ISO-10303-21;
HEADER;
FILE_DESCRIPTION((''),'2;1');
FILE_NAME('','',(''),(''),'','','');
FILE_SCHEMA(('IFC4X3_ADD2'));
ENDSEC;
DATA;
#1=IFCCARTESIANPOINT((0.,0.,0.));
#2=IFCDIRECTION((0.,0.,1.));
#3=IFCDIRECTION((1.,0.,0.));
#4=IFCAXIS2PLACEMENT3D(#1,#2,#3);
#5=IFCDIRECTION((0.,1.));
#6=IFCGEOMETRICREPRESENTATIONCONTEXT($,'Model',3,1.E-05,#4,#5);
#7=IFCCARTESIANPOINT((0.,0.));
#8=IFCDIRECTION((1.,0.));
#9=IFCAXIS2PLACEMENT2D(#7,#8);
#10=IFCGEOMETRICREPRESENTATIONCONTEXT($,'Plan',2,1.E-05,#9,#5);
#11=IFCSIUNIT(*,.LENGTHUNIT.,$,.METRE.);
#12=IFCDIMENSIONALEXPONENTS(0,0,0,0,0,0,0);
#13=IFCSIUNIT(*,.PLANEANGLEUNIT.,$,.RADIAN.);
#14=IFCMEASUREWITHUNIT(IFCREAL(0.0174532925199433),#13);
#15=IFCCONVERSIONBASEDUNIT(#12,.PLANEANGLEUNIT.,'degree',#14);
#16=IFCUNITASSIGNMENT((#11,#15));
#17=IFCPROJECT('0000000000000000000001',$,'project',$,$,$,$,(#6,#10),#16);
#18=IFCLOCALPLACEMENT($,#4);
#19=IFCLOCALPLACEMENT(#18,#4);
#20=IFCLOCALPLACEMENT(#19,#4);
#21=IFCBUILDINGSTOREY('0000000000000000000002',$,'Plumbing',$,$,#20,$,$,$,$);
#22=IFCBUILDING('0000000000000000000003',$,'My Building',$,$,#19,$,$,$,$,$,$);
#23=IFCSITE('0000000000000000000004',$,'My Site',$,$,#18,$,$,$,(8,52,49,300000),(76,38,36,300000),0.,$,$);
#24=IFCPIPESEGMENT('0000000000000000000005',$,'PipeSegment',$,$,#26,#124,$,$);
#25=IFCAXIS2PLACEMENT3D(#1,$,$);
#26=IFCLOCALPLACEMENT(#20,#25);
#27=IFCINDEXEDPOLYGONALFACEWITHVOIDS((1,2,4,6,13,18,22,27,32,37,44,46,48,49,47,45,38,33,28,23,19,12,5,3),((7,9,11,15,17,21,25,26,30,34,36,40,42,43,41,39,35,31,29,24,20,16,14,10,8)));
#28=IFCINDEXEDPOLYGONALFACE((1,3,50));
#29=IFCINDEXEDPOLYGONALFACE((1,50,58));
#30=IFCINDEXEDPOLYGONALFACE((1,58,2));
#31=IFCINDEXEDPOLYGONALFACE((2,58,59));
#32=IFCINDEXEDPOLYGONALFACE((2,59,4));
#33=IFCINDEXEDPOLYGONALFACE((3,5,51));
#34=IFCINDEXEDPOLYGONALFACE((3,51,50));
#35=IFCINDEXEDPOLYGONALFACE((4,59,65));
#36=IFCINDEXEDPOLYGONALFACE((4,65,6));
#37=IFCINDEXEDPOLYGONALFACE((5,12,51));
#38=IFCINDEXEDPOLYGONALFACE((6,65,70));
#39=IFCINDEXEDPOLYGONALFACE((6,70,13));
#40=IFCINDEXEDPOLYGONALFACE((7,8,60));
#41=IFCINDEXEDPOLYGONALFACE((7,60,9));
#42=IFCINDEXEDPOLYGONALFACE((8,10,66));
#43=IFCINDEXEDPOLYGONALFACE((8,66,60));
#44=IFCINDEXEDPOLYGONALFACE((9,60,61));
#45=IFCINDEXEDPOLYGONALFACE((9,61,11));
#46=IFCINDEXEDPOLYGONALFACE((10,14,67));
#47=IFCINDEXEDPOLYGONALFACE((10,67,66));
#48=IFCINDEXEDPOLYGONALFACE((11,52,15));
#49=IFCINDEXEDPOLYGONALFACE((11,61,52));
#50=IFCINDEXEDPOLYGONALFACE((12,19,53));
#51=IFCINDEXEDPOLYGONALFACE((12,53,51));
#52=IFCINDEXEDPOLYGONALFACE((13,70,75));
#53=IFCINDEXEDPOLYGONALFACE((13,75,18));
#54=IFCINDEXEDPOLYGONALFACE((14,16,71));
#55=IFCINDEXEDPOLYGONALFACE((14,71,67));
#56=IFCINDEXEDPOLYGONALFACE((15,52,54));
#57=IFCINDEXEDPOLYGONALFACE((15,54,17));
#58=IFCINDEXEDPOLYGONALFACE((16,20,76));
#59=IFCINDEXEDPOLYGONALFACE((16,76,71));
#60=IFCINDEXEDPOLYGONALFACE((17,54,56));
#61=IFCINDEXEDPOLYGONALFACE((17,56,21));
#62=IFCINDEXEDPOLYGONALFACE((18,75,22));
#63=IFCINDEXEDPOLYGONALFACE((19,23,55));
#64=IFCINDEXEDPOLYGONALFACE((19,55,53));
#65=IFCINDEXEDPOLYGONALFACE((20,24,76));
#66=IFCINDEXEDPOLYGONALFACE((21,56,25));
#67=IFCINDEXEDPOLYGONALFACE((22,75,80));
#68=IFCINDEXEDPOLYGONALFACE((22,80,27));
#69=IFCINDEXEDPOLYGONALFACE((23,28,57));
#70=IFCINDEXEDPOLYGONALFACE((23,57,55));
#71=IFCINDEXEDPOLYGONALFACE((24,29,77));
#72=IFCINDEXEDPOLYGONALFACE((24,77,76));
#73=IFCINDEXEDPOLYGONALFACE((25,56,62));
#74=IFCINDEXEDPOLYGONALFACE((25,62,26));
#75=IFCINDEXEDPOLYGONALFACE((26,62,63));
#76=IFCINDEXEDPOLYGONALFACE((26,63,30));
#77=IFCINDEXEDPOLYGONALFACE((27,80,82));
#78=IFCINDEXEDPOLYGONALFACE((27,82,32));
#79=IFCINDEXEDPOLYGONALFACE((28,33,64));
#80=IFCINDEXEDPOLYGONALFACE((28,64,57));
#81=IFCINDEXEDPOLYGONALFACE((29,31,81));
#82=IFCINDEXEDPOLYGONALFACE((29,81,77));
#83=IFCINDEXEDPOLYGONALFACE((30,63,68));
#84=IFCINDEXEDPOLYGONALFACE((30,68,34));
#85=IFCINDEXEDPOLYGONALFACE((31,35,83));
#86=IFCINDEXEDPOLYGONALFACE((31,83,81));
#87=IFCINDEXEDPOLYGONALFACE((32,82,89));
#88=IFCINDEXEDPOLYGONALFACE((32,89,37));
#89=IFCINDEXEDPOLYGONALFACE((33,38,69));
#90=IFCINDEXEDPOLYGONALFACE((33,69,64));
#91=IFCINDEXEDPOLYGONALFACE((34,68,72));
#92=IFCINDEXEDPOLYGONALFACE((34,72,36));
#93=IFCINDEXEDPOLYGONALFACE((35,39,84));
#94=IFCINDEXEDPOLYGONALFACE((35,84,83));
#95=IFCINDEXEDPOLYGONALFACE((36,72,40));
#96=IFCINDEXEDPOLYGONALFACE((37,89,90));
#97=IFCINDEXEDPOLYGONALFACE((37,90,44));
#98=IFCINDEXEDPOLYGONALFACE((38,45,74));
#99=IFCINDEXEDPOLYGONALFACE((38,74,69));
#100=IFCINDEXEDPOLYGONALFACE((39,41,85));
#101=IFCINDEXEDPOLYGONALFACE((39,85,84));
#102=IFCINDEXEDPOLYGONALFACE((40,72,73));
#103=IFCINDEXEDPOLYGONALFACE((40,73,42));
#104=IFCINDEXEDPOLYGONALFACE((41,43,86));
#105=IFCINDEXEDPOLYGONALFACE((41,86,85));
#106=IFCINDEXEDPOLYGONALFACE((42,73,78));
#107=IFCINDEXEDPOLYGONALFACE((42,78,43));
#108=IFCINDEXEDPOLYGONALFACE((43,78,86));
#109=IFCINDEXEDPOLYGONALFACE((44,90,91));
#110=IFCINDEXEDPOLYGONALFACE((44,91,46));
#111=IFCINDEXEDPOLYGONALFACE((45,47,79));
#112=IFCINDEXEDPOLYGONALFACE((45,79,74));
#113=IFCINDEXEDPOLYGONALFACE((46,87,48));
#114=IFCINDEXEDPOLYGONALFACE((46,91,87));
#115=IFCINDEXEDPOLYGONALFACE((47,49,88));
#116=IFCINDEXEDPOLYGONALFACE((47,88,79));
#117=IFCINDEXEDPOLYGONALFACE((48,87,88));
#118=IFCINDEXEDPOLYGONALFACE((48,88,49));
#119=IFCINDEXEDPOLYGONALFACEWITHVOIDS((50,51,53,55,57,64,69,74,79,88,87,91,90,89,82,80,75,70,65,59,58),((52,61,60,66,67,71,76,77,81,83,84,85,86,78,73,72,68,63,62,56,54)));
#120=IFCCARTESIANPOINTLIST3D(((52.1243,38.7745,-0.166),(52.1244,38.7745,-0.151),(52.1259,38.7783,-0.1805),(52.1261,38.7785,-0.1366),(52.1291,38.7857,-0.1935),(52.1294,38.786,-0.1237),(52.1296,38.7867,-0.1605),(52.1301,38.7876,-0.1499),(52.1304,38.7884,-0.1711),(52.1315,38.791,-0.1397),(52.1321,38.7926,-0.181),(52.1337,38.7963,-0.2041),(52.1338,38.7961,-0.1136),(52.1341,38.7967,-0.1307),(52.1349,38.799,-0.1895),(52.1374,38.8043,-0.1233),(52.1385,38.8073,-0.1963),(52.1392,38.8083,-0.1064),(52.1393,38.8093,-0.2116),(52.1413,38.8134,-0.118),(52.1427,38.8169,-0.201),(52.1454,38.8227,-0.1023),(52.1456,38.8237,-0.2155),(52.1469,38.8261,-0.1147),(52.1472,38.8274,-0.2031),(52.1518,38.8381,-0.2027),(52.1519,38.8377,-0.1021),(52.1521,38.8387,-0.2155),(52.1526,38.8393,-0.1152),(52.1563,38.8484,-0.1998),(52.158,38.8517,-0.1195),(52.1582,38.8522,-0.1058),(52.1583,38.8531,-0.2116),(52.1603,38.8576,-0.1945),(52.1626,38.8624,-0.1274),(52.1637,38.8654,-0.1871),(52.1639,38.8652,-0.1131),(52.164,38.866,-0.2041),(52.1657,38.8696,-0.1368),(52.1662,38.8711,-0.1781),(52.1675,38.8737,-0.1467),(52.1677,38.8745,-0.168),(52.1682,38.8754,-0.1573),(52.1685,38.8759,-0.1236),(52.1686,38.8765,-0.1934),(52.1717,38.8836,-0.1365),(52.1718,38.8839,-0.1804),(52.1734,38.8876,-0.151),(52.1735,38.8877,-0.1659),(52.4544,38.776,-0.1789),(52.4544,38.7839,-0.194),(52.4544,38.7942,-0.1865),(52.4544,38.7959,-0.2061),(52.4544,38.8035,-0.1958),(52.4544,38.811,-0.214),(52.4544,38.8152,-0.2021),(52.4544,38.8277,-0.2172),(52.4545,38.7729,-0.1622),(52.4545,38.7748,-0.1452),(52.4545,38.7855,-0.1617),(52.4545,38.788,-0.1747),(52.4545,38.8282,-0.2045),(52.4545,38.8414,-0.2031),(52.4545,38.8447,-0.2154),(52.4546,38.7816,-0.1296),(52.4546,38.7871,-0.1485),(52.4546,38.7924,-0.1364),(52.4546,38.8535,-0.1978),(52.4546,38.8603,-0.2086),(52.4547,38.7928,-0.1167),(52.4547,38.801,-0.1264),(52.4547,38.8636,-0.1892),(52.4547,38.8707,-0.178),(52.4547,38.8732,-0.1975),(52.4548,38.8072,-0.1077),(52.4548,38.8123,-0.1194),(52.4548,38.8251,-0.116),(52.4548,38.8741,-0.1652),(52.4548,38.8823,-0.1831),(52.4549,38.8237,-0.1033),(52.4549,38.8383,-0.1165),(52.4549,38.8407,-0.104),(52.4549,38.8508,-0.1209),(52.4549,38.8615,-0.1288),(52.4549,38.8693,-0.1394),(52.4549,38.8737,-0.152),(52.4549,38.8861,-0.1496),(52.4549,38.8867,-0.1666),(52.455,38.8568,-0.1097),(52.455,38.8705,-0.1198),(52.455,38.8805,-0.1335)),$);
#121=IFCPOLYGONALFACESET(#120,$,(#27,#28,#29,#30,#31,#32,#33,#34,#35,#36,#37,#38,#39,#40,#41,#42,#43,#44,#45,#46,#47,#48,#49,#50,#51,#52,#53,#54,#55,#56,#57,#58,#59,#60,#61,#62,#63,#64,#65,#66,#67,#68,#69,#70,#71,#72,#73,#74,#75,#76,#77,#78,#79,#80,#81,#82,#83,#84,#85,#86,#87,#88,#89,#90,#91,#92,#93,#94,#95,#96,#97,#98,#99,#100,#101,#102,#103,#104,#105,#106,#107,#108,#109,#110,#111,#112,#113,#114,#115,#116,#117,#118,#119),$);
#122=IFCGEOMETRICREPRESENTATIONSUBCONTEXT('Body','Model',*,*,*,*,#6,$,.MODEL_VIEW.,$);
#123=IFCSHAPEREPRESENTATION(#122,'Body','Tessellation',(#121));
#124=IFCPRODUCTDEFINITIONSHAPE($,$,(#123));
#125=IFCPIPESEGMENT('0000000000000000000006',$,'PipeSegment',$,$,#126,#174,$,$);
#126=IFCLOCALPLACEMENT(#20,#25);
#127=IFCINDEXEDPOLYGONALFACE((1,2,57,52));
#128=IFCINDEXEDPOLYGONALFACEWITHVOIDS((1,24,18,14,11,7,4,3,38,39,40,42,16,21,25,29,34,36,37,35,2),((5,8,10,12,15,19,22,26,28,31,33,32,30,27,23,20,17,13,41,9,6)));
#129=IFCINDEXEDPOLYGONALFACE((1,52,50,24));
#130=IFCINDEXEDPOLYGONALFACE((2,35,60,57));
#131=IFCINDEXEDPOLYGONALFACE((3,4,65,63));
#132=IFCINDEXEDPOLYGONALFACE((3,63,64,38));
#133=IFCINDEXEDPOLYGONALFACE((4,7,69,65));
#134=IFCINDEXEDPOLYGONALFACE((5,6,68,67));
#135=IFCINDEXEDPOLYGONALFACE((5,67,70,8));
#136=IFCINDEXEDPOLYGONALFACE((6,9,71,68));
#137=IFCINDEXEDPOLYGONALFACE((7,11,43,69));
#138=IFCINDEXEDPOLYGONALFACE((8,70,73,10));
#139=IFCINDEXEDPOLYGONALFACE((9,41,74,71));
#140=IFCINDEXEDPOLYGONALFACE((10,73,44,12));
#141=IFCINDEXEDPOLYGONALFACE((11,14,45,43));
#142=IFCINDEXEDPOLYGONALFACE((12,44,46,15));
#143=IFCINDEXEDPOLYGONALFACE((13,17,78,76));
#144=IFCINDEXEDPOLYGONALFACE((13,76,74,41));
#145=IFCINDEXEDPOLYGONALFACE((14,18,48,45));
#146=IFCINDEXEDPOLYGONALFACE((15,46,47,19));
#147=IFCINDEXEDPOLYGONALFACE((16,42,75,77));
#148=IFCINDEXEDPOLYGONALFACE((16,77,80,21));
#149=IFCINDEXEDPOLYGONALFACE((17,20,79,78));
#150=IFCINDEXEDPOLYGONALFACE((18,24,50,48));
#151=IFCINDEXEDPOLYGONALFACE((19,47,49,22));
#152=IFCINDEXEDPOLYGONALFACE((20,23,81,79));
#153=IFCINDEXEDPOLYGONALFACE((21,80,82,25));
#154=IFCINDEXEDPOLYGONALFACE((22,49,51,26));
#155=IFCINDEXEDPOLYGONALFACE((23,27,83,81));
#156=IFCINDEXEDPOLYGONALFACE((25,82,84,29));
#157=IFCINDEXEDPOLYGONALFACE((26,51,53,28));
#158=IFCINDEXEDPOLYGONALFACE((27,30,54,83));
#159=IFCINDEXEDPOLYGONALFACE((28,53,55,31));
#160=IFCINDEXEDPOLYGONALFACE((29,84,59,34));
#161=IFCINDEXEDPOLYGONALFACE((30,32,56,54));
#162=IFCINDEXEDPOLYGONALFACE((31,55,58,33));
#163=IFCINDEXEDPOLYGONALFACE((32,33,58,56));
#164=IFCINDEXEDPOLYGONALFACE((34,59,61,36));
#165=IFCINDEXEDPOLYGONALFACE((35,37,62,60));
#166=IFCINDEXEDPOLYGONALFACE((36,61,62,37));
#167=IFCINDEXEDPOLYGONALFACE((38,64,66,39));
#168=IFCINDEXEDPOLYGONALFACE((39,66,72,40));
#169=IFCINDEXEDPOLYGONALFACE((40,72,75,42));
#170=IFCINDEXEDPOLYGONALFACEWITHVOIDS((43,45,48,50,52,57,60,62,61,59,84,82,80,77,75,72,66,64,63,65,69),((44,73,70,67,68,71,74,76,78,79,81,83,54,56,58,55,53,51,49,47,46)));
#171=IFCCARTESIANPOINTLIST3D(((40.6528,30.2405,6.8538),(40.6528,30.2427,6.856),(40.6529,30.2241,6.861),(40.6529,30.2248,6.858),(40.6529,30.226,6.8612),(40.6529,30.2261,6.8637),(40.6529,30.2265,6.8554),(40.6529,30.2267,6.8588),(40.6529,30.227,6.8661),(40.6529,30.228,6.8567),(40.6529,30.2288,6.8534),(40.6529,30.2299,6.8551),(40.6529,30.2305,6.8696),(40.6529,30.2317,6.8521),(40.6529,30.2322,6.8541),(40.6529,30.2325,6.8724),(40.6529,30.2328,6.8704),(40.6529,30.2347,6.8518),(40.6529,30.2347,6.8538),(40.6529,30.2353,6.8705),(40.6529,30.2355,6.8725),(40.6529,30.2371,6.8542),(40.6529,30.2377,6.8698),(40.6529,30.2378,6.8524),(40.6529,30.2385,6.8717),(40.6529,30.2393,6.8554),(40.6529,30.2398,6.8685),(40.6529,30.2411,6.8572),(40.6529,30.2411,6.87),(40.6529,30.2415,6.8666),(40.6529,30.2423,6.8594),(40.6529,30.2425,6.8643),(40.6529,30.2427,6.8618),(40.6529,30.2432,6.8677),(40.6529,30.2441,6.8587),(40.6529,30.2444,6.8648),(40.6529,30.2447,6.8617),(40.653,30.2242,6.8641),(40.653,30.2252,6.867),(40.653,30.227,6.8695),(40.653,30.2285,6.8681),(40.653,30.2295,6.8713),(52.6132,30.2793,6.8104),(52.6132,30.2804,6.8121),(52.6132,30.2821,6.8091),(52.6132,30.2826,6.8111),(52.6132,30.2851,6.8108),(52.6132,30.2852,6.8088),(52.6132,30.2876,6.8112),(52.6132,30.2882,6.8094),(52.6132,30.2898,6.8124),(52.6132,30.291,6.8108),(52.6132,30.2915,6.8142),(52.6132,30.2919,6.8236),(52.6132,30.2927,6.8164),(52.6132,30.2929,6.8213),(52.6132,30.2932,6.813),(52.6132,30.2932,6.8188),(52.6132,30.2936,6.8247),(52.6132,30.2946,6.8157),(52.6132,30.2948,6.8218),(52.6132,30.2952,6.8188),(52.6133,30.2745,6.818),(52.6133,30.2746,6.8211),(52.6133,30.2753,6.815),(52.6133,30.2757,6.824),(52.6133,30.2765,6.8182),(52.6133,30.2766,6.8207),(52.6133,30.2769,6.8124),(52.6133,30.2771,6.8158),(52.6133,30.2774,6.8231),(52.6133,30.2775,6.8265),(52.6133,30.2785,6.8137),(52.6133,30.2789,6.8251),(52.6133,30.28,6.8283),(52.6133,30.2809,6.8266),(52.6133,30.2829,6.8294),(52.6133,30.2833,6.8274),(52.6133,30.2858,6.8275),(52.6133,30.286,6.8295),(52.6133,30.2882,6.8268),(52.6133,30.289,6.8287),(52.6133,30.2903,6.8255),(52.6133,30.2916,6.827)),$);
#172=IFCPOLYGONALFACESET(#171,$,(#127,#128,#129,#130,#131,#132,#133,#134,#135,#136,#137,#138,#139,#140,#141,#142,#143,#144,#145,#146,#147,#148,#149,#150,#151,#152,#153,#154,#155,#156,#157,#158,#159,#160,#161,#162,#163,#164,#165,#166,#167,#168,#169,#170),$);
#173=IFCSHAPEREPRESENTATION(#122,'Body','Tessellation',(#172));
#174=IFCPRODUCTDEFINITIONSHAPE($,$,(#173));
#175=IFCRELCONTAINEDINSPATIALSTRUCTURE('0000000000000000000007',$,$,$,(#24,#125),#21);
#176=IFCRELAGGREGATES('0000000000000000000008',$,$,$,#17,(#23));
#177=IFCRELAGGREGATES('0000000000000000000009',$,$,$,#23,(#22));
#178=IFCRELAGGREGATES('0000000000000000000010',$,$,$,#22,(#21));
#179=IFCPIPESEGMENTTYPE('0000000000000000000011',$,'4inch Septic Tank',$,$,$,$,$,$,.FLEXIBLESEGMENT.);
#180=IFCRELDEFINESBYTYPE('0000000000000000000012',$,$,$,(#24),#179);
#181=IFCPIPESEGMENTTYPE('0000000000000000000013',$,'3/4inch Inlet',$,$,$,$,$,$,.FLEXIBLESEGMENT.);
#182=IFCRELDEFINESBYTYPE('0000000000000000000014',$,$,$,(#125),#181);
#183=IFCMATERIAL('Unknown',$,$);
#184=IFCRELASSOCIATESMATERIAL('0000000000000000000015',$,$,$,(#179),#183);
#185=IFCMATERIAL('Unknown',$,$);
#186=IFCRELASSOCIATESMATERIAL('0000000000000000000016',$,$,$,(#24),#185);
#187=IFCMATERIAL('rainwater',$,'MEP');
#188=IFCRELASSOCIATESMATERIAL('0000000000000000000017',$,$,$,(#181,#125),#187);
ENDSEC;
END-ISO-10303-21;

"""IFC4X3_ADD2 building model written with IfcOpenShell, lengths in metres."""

from ifc_helpers import new_model, entity, si_unit, converted_unit, direction, frame, origin_with_axes, origin_2d_with_axis, place, context, subcontext, project, spatial, hollow_circle, extrude, clip, halfspace, material, material_profile, profile_set, profile_usage, type_object, element, save


model = new_model("IFC4X3_ADD2")

# Units and contexts
model_context = context("Model", 3, precision=1e-05, world=origin_with_axes(), true_north=direction((0.0, 1.0)))
plan_context = context("Plan", 2, precision=1e-05, world=origin_2d_with_axis(), true_north=direction((0.0, 1.0)))
body_context_1 = subcontext(model_context, "Body", "Model", "MODEL_VIEW")
ifc_project = project(units=[si_unit("LENGTHUNIT", "METRE"), converted_unit("PLANEANGLEUNIT", "degree", entity("IfcReal", 0.0174532925199433), si_unit("PLANEANGLEUNIT", "RADIAN"), dimensions=[0, 0, 0, 0, 0, 0, 0])], contexts=[model_context, plan_context])

# Site, building, storey
site_placement = place(None, origin_with_axes())
site = spatial("IfcSite", under=ifc_project, at=site_placement, Name="My Site", RefLatitude=(8, 52, 49, 300000), RefLongitude=(76, 38, 36, 300000), RefElevation=0.0)
building_placement = place(site_placement, origin_with_axes())
building = spatial("IfcBuilding", under=site, at=building_placement, Name="My Building")
storey_placement = place(building_placement, origin_with_axes())
storey = spatial("IfcBuildingStorey", under=building, at=storey_placement, Name="Plumbing")

# Pipe segment
ifc_material_1 = material(Name="Unknown")
ifc_material_2 = material(Name="Unknown")
ifc_material_profile_1 = material_profile(ifc_material_2, hollow_circle(Radius=0.0571, WallThickness=0.0127))
ifc_profile_set_1 = profile_set([ifc_material_profile_1], Name="blackwater")
ifc_material_profile_2 = material_profile(ifc_material_1, hollow_circle(Radius=0.0571, WallThickness=0.0127))
ifc_profile_set_2 = profile_set([ifc_material_profile_2], Name="blackwater")
pipe_segment_type_1 = type_object("IfcPipeSegmentType", Name="4inch Septic Tank", PredefinedType="FLEXIBLESEGMENT", material=ifc_profile_set_2)
ifc_profile_usage_1 = profile_usage(ifc_profile_set_1, cardinal=5)
pipe_segment_1_placement = place(storey_placement, frame((52.4547, 38.83, -0.1601), z_axis=(-0.999985, 0.003594, 0.004219), x_axis=(0.002438, -0.398179, 0.917304)))
element("IfcPipeSegment", 1, at=pipe_segment_1_placement, inside=storey, type_object=pipe_segment_type_1, material=ifc_profile_usage_1, Name="PipeSegment", context=body_context_1, shape_type="Clipping", body=[
    clip(extrude(hollow_circle(Radius=0.0571, WallThickness=0.0127), origin_with_axes(), (0.0, 0.0, 1.0), 0.4201), halfspace(frame((-0.1528, -0.097, 0.3176), z_axis=(-0.158546, 0.361655, 0.918732), x_axis=(0.915857, 0.401504, 0.0)), False)),
])

# Pipe segment
ifc_material_3 = material(Name="rainwater", Category="MEP")
ifc_material_profile_3 = material_profile(ifc_material_3, hollow_circle(Radius=0.0104, WallThickness=0.002))
ifc_profile_set_3 = profile_set([ifc_material_profile_3], Name="water")
pipe_segment_type_2 = type_object("IfcPipeSegmentType", Name="3/4inch Inlet", PredefinedType="FLEXIBLESEGMENT", material=ifc_profile_set_3)
ifc_profile_usage_2 = profile_usage(ifc_profile_set_3, cardinal=5)
pipe_segment_2_placement = place(storey_placement, frame((52.6133, 30.2848, 6.8192), z_axis=(-0.999985, -0.004219, 0.003595), x_axis=(0.002438, -0.917305, -0.398179)))
element("IfcPipeSegment", 2, at=pipe_segment_2_placement, inside=storey, type_object=pipe_segment_type_2, material=ifc_profile_usage_2, Name="PipeSegment", context=body_context_1, shape_type="SweptSolid", body=[
    extrude(hollow_circle(Radius=0.0104, WallThickness=0.002), origin_with_axes(), (0.0, 0.0, 1.0), 11.9605),
])

save(model, "model.ifc")
